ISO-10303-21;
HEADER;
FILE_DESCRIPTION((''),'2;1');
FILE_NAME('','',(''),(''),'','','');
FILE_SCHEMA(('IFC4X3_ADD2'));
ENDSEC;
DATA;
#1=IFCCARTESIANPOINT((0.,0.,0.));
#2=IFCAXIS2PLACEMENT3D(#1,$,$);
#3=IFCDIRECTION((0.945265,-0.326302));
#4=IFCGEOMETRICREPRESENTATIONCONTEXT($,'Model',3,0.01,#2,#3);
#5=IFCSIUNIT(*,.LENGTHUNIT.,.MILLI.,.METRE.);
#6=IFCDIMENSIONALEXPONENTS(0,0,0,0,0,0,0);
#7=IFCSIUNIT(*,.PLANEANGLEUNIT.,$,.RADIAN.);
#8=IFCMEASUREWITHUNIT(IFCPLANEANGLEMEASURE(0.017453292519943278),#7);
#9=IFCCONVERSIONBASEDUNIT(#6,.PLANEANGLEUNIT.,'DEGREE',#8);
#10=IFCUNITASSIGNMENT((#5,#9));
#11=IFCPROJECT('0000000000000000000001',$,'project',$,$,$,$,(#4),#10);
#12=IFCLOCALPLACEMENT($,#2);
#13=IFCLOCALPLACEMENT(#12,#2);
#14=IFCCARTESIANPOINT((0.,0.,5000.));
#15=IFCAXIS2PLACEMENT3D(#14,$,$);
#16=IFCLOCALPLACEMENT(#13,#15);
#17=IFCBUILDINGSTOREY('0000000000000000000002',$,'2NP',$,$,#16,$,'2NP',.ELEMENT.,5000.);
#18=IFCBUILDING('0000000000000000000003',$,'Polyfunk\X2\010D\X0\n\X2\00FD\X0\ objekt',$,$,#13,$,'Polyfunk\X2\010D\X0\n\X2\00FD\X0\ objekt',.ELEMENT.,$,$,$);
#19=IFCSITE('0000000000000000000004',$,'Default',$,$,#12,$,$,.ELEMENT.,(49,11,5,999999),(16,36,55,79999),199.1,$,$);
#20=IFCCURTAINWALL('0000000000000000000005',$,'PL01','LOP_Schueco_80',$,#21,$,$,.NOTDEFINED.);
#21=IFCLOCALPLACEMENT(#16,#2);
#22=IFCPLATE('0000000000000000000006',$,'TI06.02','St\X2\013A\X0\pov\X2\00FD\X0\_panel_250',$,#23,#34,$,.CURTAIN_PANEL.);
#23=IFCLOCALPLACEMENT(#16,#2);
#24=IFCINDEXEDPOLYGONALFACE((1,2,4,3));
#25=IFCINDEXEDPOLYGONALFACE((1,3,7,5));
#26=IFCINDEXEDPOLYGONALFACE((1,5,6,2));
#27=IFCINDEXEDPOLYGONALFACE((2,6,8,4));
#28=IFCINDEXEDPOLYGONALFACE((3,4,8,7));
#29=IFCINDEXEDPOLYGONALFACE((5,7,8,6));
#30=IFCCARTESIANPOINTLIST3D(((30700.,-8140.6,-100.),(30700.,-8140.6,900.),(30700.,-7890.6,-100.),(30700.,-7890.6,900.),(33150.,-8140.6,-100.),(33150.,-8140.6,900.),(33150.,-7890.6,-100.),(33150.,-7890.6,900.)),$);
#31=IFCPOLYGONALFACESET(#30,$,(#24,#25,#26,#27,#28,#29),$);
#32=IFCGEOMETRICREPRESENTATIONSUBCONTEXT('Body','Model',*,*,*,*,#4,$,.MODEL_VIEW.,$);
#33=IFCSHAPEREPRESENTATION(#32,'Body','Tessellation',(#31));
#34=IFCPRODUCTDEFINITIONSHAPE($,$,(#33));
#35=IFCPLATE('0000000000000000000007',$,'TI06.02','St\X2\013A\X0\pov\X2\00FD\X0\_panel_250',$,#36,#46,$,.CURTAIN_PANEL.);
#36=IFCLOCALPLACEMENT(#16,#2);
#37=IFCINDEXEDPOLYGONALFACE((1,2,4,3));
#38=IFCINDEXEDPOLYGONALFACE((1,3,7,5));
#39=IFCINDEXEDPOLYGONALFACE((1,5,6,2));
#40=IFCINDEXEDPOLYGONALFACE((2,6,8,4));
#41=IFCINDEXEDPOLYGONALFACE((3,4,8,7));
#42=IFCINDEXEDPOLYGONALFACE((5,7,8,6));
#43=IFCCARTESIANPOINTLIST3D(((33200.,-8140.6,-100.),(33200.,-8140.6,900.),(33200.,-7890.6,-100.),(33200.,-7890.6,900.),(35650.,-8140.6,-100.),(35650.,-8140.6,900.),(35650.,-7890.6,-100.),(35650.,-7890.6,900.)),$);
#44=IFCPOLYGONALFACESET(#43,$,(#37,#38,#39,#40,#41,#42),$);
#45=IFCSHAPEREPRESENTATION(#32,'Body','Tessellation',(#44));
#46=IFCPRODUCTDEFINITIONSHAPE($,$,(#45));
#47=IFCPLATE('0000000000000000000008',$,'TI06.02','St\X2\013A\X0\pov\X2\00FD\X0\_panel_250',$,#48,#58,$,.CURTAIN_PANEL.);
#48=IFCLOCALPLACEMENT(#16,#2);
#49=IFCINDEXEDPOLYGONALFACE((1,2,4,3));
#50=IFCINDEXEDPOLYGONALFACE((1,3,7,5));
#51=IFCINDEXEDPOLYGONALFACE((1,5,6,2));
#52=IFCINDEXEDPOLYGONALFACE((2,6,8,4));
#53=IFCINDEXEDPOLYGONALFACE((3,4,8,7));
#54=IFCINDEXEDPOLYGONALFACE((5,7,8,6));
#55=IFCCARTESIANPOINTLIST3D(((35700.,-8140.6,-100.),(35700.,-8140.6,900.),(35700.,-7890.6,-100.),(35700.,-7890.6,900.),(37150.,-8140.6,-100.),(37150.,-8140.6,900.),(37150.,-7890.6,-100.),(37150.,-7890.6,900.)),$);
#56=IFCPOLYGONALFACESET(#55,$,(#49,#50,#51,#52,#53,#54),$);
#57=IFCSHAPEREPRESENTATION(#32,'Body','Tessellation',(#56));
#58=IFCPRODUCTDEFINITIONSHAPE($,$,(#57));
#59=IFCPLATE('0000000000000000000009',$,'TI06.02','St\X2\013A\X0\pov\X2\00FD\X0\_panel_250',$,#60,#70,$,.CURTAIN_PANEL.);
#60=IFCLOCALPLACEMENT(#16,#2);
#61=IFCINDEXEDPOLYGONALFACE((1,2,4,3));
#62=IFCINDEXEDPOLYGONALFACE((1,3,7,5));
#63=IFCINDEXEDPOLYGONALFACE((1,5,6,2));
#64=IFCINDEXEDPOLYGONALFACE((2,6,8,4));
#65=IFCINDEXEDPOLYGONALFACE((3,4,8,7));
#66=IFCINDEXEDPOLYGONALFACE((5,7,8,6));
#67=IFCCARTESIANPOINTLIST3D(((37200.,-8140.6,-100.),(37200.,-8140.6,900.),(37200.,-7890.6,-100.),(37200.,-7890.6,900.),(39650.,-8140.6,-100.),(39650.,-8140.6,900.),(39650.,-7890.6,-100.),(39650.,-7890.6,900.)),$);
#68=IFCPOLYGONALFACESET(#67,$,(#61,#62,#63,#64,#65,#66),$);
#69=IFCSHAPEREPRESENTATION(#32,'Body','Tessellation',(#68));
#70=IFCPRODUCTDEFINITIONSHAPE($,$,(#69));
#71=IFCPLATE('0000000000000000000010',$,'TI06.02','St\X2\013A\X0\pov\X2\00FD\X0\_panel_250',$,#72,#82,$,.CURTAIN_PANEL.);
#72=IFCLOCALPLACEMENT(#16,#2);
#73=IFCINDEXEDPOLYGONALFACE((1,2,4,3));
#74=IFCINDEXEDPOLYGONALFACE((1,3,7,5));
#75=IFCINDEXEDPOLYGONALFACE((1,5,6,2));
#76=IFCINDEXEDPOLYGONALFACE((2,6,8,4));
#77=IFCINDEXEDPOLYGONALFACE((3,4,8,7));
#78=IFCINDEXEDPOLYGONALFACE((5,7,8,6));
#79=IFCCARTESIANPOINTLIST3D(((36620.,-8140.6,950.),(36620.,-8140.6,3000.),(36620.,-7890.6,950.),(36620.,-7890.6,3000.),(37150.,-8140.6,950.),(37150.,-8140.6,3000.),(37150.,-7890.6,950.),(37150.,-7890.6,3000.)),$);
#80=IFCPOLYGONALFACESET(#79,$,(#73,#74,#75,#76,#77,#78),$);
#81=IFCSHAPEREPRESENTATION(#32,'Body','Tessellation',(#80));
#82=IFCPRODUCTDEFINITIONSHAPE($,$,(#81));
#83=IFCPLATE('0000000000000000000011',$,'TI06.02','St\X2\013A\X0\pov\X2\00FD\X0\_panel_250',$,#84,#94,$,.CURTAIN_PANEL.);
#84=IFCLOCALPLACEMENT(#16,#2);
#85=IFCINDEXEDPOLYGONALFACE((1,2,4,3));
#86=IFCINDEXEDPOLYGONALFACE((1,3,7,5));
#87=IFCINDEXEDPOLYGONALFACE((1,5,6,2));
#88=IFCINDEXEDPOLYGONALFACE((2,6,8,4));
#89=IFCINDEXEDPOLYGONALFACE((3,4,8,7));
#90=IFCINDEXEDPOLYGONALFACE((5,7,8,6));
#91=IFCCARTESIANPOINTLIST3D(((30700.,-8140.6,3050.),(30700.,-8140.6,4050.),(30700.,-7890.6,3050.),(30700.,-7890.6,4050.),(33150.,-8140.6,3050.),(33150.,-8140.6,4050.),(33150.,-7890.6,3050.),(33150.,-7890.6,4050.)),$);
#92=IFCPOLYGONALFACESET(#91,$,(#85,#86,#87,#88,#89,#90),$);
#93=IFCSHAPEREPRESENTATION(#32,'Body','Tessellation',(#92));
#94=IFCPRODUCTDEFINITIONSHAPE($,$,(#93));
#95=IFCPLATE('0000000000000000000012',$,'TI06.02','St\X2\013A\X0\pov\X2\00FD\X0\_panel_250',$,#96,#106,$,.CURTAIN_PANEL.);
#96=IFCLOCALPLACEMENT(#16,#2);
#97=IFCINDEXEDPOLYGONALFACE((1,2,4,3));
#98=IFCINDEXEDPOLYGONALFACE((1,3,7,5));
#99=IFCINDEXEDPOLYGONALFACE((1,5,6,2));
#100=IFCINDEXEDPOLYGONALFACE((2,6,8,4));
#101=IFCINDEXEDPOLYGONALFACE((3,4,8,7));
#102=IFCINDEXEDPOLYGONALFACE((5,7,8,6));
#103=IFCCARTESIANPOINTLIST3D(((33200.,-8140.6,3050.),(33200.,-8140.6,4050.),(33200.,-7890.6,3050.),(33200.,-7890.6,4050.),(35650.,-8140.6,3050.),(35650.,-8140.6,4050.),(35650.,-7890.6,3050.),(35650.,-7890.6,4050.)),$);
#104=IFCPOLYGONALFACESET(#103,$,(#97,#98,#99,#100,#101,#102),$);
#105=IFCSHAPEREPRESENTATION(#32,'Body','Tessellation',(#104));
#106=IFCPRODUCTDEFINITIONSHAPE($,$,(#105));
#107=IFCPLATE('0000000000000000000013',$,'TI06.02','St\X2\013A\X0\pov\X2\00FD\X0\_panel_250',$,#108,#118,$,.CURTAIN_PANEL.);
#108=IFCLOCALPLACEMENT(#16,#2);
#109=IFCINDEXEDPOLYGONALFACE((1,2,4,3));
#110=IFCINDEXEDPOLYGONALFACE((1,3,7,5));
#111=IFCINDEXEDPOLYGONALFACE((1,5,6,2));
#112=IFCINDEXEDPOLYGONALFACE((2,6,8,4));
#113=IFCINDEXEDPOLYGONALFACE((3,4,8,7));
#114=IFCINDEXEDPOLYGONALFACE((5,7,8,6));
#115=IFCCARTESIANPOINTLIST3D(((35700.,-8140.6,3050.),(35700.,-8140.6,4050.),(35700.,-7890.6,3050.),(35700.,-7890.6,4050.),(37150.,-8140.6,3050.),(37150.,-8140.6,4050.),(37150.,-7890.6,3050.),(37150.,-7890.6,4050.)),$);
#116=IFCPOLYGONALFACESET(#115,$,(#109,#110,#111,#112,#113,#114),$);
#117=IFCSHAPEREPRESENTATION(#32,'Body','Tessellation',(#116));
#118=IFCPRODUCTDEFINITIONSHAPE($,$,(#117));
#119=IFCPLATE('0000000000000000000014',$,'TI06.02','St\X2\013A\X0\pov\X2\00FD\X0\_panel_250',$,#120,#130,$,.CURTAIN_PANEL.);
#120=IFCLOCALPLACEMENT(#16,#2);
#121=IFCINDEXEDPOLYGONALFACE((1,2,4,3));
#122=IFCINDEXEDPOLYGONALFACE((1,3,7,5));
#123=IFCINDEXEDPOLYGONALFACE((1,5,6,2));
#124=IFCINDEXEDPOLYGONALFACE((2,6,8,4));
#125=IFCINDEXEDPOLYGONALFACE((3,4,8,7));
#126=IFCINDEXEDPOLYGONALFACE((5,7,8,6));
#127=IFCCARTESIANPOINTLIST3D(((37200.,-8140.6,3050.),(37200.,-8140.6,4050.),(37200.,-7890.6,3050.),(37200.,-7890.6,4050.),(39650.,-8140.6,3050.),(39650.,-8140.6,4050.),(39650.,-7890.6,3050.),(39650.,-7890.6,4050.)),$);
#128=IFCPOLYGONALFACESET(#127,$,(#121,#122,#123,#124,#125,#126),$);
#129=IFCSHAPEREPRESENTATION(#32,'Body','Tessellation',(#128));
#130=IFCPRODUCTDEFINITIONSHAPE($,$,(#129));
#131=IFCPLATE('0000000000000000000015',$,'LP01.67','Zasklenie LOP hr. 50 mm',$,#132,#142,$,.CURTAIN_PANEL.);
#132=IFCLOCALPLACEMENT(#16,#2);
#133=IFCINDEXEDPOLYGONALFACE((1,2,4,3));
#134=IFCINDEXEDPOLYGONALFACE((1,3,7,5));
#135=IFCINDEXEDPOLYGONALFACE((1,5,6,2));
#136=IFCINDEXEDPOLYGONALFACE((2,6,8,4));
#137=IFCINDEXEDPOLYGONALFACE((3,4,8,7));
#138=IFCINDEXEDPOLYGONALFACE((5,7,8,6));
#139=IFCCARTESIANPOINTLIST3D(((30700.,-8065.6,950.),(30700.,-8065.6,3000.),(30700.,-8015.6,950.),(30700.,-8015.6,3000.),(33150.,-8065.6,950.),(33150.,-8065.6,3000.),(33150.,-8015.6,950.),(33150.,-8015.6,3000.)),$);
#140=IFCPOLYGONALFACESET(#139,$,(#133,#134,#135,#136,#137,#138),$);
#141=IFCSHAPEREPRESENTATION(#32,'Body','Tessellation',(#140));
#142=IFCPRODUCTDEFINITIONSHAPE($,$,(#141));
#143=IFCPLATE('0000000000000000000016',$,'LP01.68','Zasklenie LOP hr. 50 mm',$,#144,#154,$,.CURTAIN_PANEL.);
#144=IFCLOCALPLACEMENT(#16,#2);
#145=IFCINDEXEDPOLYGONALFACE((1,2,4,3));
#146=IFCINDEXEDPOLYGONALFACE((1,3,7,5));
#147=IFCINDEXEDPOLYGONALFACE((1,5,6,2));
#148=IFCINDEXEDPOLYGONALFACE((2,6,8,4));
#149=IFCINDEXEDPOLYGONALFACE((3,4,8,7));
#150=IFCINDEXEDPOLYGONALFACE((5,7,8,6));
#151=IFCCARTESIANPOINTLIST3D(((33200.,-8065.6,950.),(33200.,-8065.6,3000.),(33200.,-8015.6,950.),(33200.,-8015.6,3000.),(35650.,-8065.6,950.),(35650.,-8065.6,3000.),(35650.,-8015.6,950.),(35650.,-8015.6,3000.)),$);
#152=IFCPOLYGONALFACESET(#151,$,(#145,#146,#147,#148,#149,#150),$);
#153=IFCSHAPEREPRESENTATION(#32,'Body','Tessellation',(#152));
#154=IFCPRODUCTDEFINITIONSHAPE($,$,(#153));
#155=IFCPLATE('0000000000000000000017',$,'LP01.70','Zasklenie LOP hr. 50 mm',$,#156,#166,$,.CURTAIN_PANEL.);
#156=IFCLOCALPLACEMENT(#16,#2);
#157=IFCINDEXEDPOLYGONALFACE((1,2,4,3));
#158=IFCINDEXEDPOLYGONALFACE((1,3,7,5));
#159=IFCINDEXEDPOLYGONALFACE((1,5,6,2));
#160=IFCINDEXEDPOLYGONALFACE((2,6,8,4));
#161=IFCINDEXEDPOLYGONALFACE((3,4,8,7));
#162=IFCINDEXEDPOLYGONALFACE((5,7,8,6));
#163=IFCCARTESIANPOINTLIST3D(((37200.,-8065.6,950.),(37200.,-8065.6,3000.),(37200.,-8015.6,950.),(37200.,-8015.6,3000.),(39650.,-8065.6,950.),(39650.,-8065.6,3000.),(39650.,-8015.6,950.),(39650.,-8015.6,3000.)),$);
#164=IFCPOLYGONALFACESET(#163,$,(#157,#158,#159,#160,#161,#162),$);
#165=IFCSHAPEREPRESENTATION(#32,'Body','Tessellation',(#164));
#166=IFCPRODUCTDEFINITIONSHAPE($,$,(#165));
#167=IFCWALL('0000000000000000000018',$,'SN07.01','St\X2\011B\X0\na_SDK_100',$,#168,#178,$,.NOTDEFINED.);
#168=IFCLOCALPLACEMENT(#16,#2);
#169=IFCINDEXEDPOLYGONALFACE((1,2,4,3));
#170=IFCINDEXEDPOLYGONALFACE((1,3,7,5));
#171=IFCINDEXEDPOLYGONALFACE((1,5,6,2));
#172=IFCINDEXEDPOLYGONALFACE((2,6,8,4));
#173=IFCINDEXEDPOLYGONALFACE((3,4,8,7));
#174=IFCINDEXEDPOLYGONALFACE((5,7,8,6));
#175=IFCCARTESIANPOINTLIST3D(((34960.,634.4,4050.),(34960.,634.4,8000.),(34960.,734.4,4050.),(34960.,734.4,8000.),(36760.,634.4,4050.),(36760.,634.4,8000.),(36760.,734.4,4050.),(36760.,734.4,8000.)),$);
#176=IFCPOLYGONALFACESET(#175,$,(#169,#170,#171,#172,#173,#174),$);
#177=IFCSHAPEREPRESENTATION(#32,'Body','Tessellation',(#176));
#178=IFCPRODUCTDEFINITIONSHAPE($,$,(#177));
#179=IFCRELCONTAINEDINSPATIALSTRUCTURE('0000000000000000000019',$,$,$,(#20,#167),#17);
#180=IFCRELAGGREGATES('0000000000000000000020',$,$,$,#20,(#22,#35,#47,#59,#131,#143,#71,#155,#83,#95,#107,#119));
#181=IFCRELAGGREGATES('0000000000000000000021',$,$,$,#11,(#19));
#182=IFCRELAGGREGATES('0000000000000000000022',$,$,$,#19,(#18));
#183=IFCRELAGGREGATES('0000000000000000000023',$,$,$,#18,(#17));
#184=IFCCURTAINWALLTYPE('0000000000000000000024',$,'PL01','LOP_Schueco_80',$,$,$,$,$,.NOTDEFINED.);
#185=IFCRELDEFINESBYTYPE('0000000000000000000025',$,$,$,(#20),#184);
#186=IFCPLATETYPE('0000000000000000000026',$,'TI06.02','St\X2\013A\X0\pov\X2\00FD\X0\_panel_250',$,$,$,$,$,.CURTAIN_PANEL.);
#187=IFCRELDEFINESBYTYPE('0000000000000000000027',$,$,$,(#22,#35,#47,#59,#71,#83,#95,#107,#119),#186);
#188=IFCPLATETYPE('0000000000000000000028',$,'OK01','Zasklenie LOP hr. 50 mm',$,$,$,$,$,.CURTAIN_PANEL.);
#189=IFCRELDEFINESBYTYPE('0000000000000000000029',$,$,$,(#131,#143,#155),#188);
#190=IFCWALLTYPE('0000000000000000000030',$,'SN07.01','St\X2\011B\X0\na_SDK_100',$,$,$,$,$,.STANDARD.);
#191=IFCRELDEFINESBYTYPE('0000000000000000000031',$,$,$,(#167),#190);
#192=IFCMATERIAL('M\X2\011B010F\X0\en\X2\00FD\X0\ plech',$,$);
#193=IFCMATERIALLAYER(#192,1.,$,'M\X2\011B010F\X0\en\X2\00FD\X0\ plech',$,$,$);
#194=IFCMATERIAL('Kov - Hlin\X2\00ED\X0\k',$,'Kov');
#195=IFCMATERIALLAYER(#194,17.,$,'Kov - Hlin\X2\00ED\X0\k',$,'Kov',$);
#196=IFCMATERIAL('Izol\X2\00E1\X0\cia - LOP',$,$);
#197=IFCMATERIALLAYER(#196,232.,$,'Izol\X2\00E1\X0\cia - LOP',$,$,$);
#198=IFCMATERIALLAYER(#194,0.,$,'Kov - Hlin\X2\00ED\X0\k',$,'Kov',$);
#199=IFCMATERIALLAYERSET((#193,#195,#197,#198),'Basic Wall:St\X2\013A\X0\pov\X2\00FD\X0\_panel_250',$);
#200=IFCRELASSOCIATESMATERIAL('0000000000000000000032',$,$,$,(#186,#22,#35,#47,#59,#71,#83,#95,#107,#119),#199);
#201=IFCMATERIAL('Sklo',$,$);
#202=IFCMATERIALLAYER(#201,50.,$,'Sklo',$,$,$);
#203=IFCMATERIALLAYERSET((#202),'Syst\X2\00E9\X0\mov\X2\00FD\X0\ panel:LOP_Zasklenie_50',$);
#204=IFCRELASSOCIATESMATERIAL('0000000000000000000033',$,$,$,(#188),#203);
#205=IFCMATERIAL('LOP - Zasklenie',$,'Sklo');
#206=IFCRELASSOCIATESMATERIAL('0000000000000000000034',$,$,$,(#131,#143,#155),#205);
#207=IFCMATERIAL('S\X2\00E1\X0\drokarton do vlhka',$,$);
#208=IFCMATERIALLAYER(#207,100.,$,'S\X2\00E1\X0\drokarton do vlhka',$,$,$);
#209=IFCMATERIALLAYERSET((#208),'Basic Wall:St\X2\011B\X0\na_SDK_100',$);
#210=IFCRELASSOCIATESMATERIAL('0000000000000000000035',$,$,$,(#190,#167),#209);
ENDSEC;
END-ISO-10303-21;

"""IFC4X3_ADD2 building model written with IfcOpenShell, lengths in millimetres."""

from ifc_helpers import new_model, entity, si_unit, converted_unit, direction, frame, frame_2d, origin, origin_2d_with_axis, place, context, subcontext, project, spatial, polyline, rectangle, extrude, clip, bounded_halfspace, source, transform, mapped, material, layer, layer_set, layer_usage, type_object, type_shapes, element, aggregate, save


model = new_model("IFC4X3_ADD2")

# Units and contexts
model_context = context("Model", 3, precision=0.01, world=origin(), true_north=direction((0.945265, -0.326302)))
body_context = subcontext(model_context, "Body", "Model", "MODEL_VIEW")
ifc_project = project(units=[si_unit("LENGTHUNIT", "METRE", prefix="MILLI"), converted_unit("PLANEANGLEUNIT", "DEGREE", entity("IfcPlaneAngleMeasure", 0.017453292519943278), si_unit("PLANEANGLEUNIT", "RADIAN"), dimensions=[0, 0, 0, 0, 0, 0, 0])], contexts=[model_context])

# Site, building, storey
site_placement = place(None, origin())
site = spatial("IfcSite", under=ifc_project, at=site_placement, Name="Default", CompositionType="ELEMENT", RefLatitude=(49, 11, 5, 999999), RefLongitude=(16, 36, 55, 79999), RefElevation=199.1)
building_placement = place(site_placement, origin())
building = spatial("IfcBuilding", under=site, at=building_placement, Name="Polyfunkčný objekt", LongName="Polyfunkčný objekt", CompositionType="ELEMENT")
storey_placement = place(building_placement, frame((0.0, 0.0, 5000.0)))
storey = spatial("IfcBuildingStorey", under=building, at=storey_placement, Name="2NP", LongName="2NP", CompositionType="ELEMENT", Elevation=5000.0)

# Curtain wall, plates
curtain_wall_type = type_object("IfcCurtainWallType", Name="PL01", Description="LOP_Schueco_80", PredefinedType="NOTDEFINED")
curtain_wall_placement = place(storey_placement, frame((0.0, 0.0, -5000.0)))
curtain_wall = element("IfcCurtainWall", 1, at=curtain_wall_placement, inside=storey, type_object=curtain_wall_type, Name="PL01", Description="LOP_Schueco_80", PredefinedType="NOTDEFINED")
ifc_material_1 = material(Name="Měďený plech")
ifc_layer_1 = layer(ifc_material_1, 1.0, Name="Měďený plech")
ifc_material_2 = material(Name="Kov - Hliník", Category="Kov")
ifc_layer_2 = layer(ifc_material_2, 17.0, Name="Kov - Hliník", Category="Kov")
ifc_material_3 = material(Name="Izolácia - LOP")
ifc_layer_3 = layer(ifc_material_3, 232.0, Name="Izolácia - LOP")
ifc_layer_4 = layer(ifc_material_2, 0.0, Name="Kov - Hliník", Category="Kov")
ifc_layer_set_1 = layer_set([ifc_layer_1, ifc_layer_2, ifc_layer_3, ifc_layer_4], Name="Basic Wall:Stĺpový_panel_250")
ifc_layer_usage_1 = layer_usage(ifc_layer_set_1, "AXIS2", "POSITIVE", -125.0)
plate_type_1 = type_object("IfcPlateType", Name="TI06.02", Description="Stĺpový_panel_250", PredefinedType="CURTAIN_PANEL", material=ifc_layer_set_1)
plate_1_placement = place(storey_placement, frame((30700.0, -8015.6, -100.0)))
plate_1 = element("IfcPlate", 2, at=plate_1_placement, type_object=plate_type_1, material=ifc_layer_usage_1, Name="TI06.02", Description="Stĺpový_panel_250", PredefinedType="CURTAIN_PANEL", context=body_context, shape_type="SweptSolid", body=[
    extrude(rectangle(XDim=250.0, YDim=2450.0, at=frame_2d((0.0, 0.0), x_axis=(1.0, 0.0))), frame((1225.0, 0.0, 0.0), z_axis=(0.0, 0.0, 1.0), x_axis=(0.0, 1.0, 0.0)), (0.0, 0.0, 1.0), 1000.0),
])
ifc_layer_usage_2 = layer_usage(ifc_layer_set_1, "AXIS2", "POSITIVE", -125.0)
plate_2_placement = place(storey_placement, frame((33200.0, -8015.6, -100.0)))
plate_2 = element("IfcPlate", 3, at=plate_2_placement, type_object=plate_type_1, material=ifc_layer_usage_2, Name="TI06.02", Description="Stĺpový_panel_250", PredefinedType="CURTAIN_PANEL", context=body_context, shape_type="SweptSolid", body=[
    extrude(rectangle(XDim=250.0, YDim=2450.0, at=frame_2d((0.0, 0.0), x_axis=(1.0, 0.0))), frame((1225.0, 0.0, 0.0), z_axis=(0.0, 0.0, 1.0), x_axis=(0.0, 1.0, 0.0)), (0.0, 0.0, 1.0), 1000.0),
])
ifc_layer_usage_3 = layer_usage(ifc_layer_set_1, "AXIS2", "POSITIVE", -125.0)
plate_3_placement = place(storey_placement, frame((35700.0, -8015.6, -100.0)))
plate_3 = element("IfcPlate", 4, at=plate_3_placement, type_object=plate_type_1, material=ifc_layer_usage_3, Name="TI06.02", Description="Stĺpový_panel_250", PredefinedType="CURTAIN_PANEL", context=body_context, shape_type="SweptSolid", body=[
    extrude(rectangle(XDim=250.0, YDim=1450.0, at=frame_2d((0.0, 0.0), x_axis=(1.0, 0.0))), frame((725.0, 0.0, 0.0), z_axis=(0.0, 0.0, 1.0), x_axis=(0.0, 1.0, 0.0)), (0.0, 0.0, 1.0), 1000.0),
])
ifc_layer_usage_4 = layer_usage(ifc_layer_set_1, "AXIS2", "POSITIVE", -125.0)
plate_4_placement = place(storey_placement, frame((37200.0, -8015.6, -100.0)))
plate_4 = element("IfcPlate", 5, at=plate_4_placement, type_object=plate_type_1, material=ifc_layer_usage_4, Name="TI06.02", Description="Stĺpový_panel_250", PredefinedType="CURTAIN_PANEL", context=body_context, shape_type="SweptSolid", body=[
    extrude(rectangle(XDim=250.0, YDim=2450.0, at=frame_2d((0.0, 0.0), x_axis=(1.0, 0.0))), frame((1225.0, 0.0, 0.0), z_axis=(0.0, 0.0, 1.0), x_axis=(0.0, 1.0, 0.0)), (0.0, 0.0, 1.0), 1000.0),
])
ifc_layer_usage_5 = layer_usage(ifc_layer_set_1, "AXIS2", "POSITIVE", -125.0)
plate_5_placement = place(storey_placement, frame((36620.0, -8015.6, 950.0)))
plate_5 = element("IfcPlate", 6, at=plate_5_placement, type_object=plate_type_1, material=ifc_layer_usage_5, Name="TI06.02", Description="Stĺpový_panel_250", PredefinedType="CURTAIN_PANEL", context=body_context, shape_type="SweptSolid", body=[
    extrude(rectangle(XDim=250.0, YDim=530.0, at=frame_2d((0.0, 0.0), x_axis=(1.0, 0.0))), frame((265.0, 0.0, 0.0), z_axis=(0.0, 0.0, 1.0), x_axis=(0.0, 1.0, 0.0)), (0.0, 0.0, 1.0), 2050.0),
])
ifc_layer_usage_6 = layer_usage(ifc_layer_set_1, "AXIS2", "POSITIVE", -125.0)
plate_6_placement = place(storey_placement, frame((30700.0, -8015.6, 3050.0)))
plate_6 = element("IfcPlate", 7, at=plate_6_placement, type_object=plate_type_1, material=ifc_layer_usage_6, Name="TI06.02", Description="Stĺpový_panel_250", PredefinedType="CURTAIN_PANEL", context=body_context, shape_type="SweptSolid", body=[
    extrude(rectangle(XDim=250.0, YDim=2450.0, at=frame_2d((0.0, 0.0), x_axis=(1.0, 0.0))), frame((1225.0, 0.0, 0.0), z_axis=(0.0, 0.0, 1.0), x_axis=(0.0, 1.0, 0.0)), (0.0, 0.0, 1.0), 1000.0),
])
ifc_layer_usage_7 = layer_usage(ifc_layer_set_1, "AXIS2", "POSITIVE", -125.0)
plate_7_placement = place(storey_placement, frame((33200.0, -8015.6, 3050.0)))
plate_7 = element("IfcPlate", 8, at=plate_7_placement, type_object=plate_type_1, material=ifc_layer_usage_7, Name="TI06.02", Description="Stĺpový_panel_250", PredefinedType="CURTAIN_PANEL", context=body_context, shape_type="SweptSolid", body=[
    extrude(rectangle(XDim=250.0, YDim=2450.0, at=frame_2d((0.0, 0.0), x_axis=(1.0, 0.0))), frame((1225.0, 0.0, 0.0), z_axis=(0.0, 0.0, 1.0), x_axis=(0.0, 1.0, 0.0)), (0.0, 0.0, 1.0), 1000.0),
])
ifc_layer_usage_8 = layer_usage(ifc_layer_set_1, "AXIS2", "POSITIVE", -125.0)
plate_8_placement = place(storey_placement, frame((35700.0, -8015.6, 3050.0)))
plate_8 = element("IfcPlate", 9, at=plate_8_placement, type_object=plate_type_1, material=ifc_layer_usage_8, Name="TI06.02", Description="Stĺpový_panel_250", PredefinedType="CURTAIN_PANEL", context=body_context, shape_type="SweptSolid", body=[
    extrude(rectangle(XDim=250.0, YDim=1450.0, at=frame_2d((0.0, 0.0), x_axis=(1.0, 0.0))), frame((725.0, 0.0, 0.0), z_axis=(0.0, 0.0, 1.0), x_axis=(0.0, 1.0, 0.0)), (0.0, 0.0, 1.0), 1000.0),
])
ifc_layer_usage_9 = layer_usage(ifc_layer_set_1, "AXIS2", "POSITIVE", -125.0)
plate_9_placement = place(storey_placement, frame((37200.0, -8015.6, 3050.0)))
plate_9 = element("IfcPlate", 10, at=plate_9_placement, type_object=plate_type_1, material=ifc_layer_usage_9, Name="TI06.02", Description="Stĺpový_panel_250", PredefinedType="CURTAIN_PANEL", context=body_context, shape_type="SweptSolid", body=[
    extrude(rectangle(XDim=250.0, YDim=2450.0, at=frame_2d((0.0, 0.0), x_axis=(1.0, 0.0))), frame((1225.0, 0.0, 0.0), z_axis=(0.0, 0.0, 1.0), x_axis=(0.0, 1.0, 0.0)), (0.0, 0.0, 1.0), 1000.0),
])
ifc_material_4 = material(Name="LOP - Zasklenie", Category="Sklo")
ifc_material_5 = material(Name="Sklo")
ifc_layer_5 = layer(ifc_material_5, 50.0, Name="Sklo")
ifc_layer_set_2 = layer_set([ifc_layer_5], Name="Systémový panel:LOP_Zasklenie_50")
plate_type_2 = type_object("IfcPlateType", Name="OK01", Description="Zasklenie LOP hr. 50 mm", PredefinedType="CURTAIN_PANEL", material=ifc_layer_set_2)
shared_shape_1 = source(origin(), body_context, "Body", "SweptSolid", [
    extrude(rectangle(XDim=50.0, YDim=2450.0, at=origin_2d_with_axis()), frame((0.0, -25.0, 0.0), z_axis=(0.0, 0.0, 1.0), x_axis=(0.0, 1.0, 0.0)), (0.0, 0.0, 1.0), 2050.0),
])
type_shapes(plate_type_2, [shared_shape_1])
plate_10_placement = place(curtain_wall_placement, frame((31925.0, -8015.6, 5950.0)))
plate_10 = element("IfcPlate", 11, at=plate_10_placement, type_object=plate_type_2, material=ifc_material_4, Name="LP01.67", Description="Zasklenie LOP hr. 50 mm", PredefinedType="CURTAIN_PANEL", context=body_context, shape_type="MappedRepresentation", body=[
    mapped(shared_shape_1, transform((0.0, 0.0, 0.0), scale=1.0)),
])
plate_11_placement = place(curtain_wall_placement, frame((34425.0, -8015.6, 5950.0)))
plate_11 = element("IfcPlate", 12, at=plate_11_placement, type_object=plate_type_2, material=ifc_material_4, Name="LP01.68", Description="Zasklenie LOP hr. 50 mm", PredefinedType="CURTAIN_PANEL", context=body_context, shape_type="MappedRepresentation", body=[
    mapped(shared_shape_1, transform((0.0, 0.0, 0.0), scale=1.0)),
])
plate_12_placement = place(curtain_wall_placement, frame((38425.0, -8015.6, 5950.0)))
plate_12 = element("IfcPlate", 13, at=plate_12_placement, type_object=plate_type_2, material=ifc_material_4, Name="LP01.70", Description="Zasklenie LOP hr. 50 mm", PredefinedType="CURTAIN_PANEL", context=body_context, shape_type="MappedRepresentation", body=[
    mapped(shared_shape_1, transform((0.0, 0.0, 0.0), scale=1.0)),
])

# Wall
ifc_material_6 = material(Name="Sádrokarton do vlhka")
ifc_layer_6 = layer(ifc_material_6, 100.0, Name="Sádrokarton do vlhka")
ifc_layer_set_3 = layer_set([ifc_layer_6], Name="Basic Wall:Stěna_SDK_100")
wall_type_1 = type_object("IfcWallType", Name="SN07.01", Description="Stěna_SDK_100", PredefinedType="STANDARD", material=ifc_layer_set_3)
wall_1_placement = place(storey_placement, frame((34960.0, 684.4, 4050.0)))
element("IfcWall", 14, at=wall_1_placement, inside=storey, type_object=wall_type_1, material=ifc_layer_set_3, Name="SN07.01", Description="Stěna_SDK_100", PredefinedType="NOTDEFINED", context=body_context, shape_type="Clipping", body=[
    clip(clip(extrude(rectangle(XDim=1800.0, YDim=100.0, at=frame_2d((900.0, 0.0), x_axis=(-1.0, 0.0))), origin(), (0.0, 0.0, 1.0), 3950.0), bounded_halfspace(frame((1800.0, -50.0, 0.0), z_axis=(0.0, 0.0, 1.0), x_axis=(-1.0, 0.0, 0.0)), True, frame((1800.0, -50.0, 0.0)), polyline([(0.0, 0.0), (0.0, 100.0), (-1800.0, 100.0), (-1800.0, 0.0), (0.0, 0.0)]))), bounded_halfspace(frame((0.0, -50.0, 3950.0), z_axis=(0.0, 0.0, -1.0), x_axis=(1.0, 0.0, 0.0)), True, frame((0.0, -50.0, 3950.0)), polyline([(0.0, 0.0), (1800.0, 0.0), (1800.0, 100.0), (0.0, 100.0), (0.0, 0.0)]))),
])

aggregate(curtain_wall, [plate_1, plate_2, plate_3, plate_4, plate_10, plate_11, plate_5, plate_12, plate_6, plate_7, plate_8, plate_9])

save(model, "model.ifc")
